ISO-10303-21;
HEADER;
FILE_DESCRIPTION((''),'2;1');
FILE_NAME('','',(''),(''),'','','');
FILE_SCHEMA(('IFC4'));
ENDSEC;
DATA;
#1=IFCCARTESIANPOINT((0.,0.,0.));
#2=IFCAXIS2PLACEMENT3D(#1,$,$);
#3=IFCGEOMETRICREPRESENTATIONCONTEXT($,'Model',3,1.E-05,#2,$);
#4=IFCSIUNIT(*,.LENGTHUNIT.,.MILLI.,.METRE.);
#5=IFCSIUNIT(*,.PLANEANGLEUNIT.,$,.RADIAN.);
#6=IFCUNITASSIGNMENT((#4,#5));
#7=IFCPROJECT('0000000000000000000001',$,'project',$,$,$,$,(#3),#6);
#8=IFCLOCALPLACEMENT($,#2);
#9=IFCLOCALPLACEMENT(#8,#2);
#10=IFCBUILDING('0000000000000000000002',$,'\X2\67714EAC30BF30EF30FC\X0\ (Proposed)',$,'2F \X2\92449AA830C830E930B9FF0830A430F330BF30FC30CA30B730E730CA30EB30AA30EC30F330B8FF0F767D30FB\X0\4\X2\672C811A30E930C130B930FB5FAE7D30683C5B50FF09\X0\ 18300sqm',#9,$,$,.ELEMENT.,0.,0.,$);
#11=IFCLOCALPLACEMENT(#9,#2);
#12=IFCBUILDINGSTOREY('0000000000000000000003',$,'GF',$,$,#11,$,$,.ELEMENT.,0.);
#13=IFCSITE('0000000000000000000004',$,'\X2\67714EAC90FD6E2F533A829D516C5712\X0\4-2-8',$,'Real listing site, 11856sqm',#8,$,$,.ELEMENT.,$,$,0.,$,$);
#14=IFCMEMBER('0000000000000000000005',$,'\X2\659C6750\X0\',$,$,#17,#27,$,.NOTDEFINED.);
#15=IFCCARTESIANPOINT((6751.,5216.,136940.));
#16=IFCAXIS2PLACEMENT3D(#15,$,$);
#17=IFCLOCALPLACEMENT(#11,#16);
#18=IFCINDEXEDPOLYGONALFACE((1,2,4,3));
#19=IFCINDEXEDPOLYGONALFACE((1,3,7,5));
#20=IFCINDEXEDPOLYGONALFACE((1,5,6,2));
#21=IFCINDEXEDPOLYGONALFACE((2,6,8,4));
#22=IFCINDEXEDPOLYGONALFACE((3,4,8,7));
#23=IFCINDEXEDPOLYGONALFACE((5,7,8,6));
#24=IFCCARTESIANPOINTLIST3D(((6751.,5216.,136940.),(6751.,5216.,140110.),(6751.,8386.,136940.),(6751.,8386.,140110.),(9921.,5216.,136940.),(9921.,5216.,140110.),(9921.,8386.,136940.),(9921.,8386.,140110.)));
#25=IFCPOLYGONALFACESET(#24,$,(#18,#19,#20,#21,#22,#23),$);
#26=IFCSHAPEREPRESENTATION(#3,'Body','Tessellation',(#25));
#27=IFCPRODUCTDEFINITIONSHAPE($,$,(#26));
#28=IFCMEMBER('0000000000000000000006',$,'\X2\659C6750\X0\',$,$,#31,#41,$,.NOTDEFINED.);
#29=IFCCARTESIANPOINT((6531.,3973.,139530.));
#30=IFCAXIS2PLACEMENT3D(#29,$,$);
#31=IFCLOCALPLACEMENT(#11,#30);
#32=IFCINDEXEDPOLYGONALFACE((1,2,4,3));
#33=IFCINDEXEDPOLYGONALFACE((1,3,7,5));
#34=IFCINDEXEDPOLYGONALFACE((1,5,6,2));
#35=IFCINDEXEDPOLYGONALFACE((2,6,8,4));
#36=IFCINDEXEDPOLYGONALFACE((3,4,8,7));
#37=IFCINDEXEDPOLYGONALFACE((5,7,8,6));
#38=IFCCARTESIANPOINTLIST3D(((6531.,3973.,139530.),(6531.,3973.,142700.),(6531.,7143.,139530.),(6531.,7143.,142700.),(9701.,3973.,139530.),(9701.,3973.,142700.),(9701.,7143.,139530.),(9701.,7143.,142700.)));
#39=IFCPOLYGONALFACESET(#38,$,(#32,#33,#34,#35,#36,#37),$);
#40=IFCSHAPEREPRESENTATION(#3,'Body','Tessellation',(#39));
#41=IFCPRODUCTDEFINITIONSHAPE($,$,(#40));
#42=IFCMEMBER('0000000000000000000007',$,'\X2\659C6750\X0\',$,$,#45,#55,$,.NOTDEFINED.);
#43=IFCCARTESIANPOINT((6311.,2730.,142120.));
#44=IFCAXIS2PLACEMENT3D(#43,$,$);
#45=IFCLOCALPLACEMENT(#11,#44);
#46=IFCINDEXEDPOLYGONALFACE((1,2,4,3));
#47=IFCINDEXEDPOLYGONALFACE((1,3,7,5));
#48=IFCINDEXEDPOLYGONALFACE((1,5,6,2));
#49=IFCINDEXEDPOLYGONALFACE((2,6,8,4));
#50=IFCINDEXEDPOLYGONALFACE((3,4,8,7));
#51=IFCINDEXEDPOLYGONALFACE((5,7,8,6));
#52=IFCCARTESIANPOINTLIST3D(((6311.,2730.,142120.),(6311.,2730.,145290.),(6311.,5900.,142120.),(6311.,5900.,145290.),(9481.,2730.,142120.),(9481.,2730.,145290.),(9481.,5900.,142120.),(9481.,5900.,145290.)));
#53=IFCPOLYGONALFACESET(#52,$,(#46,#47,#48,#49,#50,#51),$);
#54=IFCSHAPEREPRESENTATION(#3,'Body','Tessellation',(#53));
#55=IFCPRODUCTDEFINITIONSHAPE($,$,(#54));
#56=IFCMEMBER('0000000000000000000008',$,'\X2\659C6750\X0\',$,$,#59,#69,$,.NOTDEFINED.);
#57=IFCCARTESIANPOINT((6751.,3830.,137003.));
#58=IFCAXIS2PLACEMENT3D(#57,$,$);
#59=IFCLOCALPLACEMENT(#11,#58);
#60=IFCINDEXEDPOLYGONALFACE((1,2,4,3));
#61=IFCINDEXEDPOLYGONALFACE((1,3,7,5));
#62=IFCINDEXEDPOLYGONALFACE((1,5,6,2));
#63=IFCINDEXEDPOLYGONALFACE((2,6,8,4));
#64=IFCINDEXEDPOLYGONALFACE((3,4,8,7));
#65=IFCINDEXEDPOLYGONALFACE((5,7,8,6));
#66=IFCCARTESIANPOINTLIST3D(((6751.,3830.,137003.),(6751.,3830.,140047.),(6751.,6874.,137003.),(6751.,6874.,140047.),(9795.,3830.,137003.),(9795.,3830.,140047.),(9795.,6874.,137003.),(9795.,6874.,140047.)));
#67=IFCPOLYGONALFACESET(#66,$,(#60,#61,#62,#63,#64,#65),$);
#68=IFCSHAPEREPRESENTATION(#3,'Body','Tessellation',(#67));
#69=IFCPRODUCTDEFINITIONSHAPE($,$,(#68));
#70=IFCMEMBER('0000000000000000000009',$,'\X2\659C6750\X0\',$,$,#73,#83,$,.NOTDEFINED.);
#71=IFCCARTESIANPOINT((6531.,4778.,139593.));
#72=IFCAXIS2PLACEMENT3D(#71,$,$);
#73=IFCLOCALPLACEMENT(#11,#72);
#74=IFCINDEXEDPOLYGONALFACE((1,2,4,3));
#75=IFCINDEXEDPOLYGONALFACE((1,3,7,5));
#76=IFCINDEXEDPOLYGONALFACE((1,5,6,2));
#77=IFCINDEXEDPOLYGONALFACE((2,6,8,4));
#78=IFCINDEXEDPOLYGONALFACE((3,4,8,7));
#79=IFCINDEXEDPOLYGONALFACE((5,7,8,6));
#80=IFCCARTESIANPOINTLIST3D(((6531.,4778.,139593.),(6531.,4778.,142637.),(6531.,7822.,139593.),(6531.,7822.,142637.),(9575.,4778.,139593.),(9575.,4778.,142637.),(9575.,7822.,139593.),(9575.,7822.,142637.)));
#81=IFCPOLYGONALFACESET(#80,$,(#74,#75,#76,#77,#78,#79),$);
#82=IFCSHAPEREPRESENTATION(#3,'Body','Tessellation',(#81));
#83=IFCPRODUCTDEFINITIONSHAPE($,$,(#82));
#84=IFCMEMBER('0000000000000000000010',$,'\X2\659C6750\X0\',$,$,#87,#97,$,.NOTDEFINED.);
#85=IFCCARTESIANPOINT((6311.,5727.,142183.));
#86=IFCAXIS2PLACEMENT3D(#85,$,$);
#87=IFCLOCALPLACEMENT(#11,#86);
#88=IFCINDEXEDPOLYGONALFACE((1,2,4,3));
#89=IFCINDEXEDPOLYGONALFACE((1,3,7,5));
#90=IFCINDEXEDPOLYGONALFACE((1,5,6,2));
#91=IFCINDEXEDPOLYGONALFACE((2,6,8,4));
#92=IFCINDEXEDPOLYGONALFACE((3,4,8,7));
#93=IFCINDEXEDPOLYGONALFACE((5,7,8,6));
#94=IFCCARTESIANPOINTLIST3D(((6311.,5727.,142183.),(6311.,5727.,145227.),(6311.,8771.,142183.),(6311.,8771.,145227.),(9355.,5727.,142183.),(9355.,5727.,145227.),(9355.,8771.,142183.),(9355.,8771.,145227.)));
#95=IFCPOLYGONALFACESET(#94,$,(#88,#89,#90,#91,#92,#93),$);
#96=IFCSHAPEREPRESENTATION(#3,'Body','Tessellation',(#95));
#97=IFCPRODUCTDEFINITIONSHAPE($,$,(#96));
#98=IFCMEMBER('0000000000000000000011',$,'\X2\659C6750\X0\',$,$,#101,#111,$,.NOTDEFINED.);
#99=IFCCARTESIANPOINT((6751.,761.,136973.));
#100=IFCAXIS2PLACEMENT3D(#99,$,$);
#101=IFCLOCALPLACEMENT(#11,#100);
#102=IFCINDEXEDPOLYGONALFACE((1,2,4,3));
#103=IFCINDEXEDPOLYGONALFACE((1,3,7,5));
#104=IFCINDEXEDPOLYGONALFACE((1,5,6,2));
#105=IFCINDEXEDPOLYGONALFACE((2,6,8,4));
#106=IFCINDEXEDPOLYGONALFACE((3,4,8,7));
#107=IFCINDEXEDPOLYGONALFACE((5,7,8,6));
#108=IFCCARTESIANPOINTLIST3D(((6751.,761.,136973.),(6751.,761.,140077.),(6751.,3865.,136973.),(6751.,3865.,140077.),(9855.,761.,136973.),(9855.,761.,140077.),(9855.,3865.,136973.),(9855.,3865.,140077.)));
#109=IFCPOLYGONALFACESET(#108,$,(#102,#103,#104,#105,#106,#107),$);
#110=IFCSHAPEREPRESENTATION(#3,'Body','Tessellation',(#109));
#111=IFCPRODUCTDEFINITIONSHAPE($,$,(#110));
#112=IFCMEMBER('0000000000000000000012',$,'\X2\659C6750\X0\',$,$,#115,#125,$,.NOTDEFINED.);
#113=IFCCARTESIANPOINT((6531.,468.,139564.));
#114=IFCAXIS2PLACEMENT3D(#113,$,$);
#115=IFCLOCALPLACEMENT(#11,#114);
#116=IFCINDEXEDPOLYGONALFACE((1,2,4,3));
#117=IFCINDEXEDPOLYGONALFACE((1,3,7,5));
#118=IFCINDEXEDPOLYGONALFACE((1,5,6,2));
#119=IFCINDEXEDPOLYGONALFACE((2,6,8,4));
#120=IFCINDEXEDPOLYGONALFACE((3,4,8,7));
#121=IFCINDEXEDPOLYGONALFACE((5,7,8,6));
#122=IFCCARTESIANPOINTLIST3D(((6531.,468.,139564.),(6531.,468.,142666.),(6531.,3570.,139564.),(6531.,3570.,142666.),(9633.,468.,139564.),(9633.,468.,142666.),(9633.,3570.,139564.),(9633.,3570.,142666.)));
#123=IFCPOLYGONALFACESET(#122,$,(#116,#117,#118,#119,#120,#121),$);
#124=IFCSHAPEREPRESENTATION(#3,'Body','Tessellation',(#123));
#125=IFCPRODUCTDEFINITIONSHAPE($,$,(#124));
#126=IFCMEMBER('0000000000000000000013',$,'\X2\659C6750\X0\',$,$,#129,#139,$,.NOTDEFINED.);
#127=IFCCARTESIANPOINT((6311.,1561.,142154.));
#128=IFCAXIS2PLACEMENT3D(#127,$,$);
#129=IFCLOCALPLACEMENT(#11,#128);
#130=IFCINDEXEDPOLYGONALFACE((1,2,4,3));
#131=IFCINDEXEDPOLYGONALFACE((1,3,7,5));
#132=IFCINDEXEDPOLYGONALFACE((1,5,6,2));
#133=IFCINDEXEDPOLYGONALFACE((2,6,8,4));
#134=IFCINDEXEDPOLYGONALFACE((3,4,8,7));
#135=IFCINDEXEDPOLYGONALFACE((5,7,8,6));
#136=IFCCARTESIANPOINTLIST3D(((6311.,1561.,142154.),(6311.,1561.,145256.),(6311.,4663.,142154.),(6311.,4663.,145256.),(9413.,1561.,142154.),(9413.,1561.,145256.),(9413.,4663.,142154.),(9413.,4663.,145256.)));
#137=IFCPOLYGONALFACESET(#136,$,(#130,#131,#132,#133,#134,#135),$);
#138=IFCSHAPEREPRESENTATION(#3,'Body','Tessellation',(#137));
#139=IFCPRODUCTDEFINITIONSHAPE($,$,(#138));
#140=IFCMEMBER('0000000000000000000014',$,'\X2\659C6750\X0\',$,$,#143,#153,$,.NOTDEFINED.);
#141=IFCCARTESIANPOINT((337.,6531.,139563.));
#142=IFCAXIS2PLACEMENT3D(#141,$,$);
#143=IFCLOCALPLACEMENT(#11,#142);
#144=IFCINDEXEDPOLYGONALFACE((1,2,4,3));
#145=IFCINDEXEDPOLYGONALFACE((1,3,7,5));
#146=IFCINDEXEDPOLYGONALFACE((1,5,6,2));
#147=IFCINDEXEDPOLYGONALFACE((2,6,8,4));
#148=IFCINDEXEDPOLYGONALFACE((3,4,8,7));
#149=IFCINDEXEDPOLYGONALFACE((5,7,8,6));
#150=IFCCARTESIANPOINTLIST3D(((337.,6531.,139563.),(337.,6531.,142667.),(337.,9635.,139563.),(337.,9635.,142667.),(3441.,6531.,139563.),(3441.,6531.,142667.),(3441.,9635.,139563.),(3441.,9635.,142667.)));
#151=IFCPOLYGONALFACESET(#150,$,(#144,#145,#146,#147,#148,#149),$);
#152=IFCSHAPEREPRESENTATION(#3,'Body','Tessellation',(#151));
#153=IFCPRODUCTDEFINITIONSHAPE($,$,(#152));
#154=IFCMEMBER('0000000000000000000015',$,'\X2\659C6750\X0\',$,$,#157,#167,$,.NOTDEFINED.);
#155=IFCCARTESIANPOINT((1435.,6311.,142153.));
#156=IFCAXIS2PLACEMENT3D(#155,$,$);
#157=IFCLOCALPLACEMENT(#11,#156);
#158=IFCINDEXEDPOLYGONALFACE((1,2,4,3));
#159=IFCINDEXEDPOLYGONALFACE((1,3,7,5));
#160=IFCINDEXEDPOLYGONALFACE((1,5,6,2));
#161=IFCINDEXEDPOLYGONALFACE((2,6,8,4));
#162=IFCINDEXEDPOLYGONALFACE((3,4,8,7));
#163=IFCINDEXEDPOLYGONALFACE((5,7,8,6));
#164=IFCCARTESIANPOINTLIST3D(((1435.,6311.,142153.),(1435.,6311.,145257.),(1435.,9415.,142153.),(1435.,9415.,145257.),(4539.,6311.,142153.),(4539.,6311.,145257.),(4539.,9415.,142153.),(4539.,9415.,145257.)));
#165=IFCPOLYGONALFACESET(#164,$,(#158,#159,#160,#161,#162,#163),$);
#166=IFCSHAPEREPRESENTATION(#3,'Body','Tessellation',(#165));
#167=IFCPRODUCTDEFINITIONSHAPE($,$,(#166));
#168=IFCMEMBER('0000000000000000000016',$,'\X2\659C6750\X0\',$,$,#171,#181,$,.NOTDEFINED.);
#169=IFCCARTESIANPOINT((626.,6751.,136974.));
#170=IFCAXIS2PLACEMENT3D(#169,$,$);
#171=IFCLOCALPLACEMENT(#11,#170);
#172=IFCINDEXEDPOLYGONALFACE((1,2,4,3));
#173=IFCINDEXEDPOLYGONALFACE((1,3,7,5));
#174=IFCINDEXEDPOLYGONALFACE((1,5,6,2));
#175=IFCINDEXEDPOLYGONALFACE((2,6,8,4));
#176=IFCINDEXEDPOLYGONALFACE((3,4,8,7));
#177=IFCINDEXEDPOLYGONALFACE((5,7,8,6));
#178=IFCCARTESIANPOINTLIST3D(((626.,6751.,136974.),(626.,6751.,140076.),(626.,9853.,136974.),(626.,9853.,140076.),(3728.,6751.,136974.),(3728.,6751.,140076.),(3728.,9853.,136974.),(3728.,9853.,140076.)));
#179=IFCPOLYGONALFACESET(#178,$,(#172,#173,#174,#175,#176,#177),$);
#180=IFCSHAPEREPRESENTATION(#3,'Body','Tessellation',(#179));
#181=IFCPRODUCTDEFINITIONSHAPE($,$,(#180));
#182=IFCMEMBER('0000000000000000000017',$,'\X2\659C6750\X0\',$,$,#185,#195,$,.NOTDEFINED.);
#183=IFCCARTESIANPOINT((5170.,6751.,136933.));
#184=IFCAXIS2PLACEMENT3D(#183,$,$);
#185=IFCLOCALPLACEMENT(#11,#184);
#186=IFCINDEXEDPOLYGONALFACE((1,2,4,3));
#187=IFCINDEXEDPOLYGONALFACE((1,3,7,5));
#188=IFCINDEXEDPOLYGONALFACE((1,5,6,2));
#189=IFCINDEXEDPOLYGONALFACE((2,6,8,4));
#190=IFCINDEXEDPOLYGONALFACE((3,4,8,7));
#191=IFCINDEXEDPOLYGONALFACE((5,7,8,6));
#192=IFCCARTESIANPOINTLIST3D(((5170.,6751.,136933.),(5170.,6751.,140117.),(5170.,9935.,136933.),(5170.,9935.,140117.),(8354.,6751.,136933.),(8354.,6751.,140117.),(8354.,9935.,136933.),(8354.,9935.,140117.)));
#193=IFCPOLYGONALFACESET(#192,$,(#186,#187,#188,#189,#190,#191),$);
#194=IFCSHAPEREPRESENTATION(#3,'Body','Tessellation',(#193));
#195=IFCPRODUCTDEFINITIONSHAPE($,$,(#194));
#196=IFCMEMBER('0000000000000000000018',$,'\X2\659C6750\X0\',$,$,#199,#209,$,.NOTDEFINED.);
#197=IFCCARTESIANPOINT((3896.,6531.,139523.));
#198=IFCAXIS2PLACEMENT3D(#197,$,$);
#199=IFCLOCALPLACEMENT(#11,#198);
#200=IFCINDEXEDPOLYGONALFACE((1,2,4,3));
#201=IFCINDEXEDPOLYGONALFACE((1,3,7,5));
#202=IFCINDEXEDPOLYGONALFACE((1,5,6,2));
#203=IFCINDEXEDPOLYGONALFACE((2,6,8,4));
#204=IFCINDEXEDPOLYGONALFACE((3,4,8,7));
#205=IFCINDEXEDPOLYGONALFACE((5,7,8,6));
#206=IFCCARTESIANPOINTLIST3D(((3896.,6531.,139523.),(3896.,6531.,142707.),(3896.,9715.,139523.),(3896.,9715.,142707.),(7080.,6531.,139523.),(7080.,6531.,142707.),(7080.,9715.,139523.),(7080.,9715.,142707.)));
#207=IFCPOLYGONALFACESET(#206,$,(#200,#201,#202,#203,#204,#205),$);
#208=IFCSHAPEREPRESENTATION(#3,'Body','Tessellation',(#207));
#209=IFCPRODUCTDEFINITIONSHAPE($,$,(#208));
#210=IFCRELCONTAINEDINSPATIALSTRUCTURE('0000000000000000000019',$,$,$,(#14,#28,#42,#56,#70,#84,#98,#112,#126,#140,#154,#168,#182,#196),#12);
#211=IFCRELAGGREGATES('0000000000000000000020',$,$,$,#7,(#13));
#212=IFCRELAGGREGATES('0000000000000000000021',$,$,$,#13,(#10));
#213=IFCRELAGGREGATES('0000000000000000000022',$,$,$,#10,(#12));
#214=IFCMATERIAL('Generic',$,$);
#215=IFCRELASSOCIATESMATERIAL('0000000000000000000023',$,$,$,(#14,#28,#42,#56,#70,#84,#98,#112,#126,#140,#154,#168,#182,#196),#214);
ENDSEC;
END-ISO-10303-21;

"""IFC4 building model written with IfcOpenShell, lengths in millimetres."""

from ifc_helpers import new_model, si_unit, frame, frame_2d, origin, place, context, project, spatial, rectangle, extrude, material, element, save


model = new_model("IFC4")

# Units and contexts
model_context = context("Model", 3, precision=1e-05, world=origin())
ifc_project = project(units=[si_unit("LENGTHUNIT", "METRE", prefix="MILLI"), si_unit("PLANEANGLEUNIT", "RADIAN")], contexts=[model_context])

# Site, building, storey
site_placement = place(None, origin())
site = spatial("IfcSite", under=ifc_project, at=site_placement, Name="東京都港区芝公園4-2-8", ObjectType="Real listing site, 11856sqm", CompositionType="ELEMENT", RefElevation=0.0)
building_placement = place(site_placement, origin())
building = spatial("IfcBuilding", under=site, at=building_placement, Name="東京タワー (Proposed)", ObjectType="2F 鉄骨トラス（インターナショナルオレンジ／白・4本脚ラチス・微細格子） 18300sqm", CompositionType="ELEMENT", ElevationOfRefHeight=0.0, ElevationOfTerrain=0.0)
storey_placement = place(building_placement, origin())
storey = spatial("IfcBuildingStorey", under=building, at=storey_placement, Name="GF", CompositionType="ELEMENT", Elevation=0.0)

# Members
ifc_material = material(Name="Generic")
member_1_placement = place(storey_placement, frame((6751.0, 5216.0, 136940.0)))
element("IfcMember", 1, at=member_1_placement, inside=storey, material=ifc_material, Name="斜材", PredefinedType="NOTDEFINED", context=model_context, shape_type="SweptSolid", body=[
    extrude(rectangle(XDim=3170.0, YDim=3170.0, at=frame_2d((1585.0, 1585.0))), frame((6751.0, 5216.0, 136940.0)), (0.0, 0.0, 1.0), 3170.0),
])
member_2_placement = place(storey_placement, frame((6531.0, 3973.0, 139530.0)))
element("IfcMember", 2, at=member_2_placement, inside=storey, material=ifc_material, Name="斜材", PredefinedType="NOTDEFINED", context=model_context, shape_type="SweptSolid", body=[
    extrude(rectangle(XDim=3170.0, YDim=3170.0, at=frame_2d((1585.0, 1585.0))), frame((6531.0, 3973.0, 139530.0)), (0.0, 0.0, 1.0), 3170.0),
])
member_3_placement = place(storey_placement, frame((6311.0, 2730.0, 142120.0)))
element("IfcMember", 3, at=member_3_placement, inside=storey, material=ifc_material, Name="斜材", PredefinedType="NOTDEFINED", context=model_context, shape_type="SweptSolid", body=[
    extrude(rectangle(XDim=3170.0, YDim=3170.0, at=frame_2d((1585.0, 1585.0))), frame((6311.0, 2730.0, 142120.0)), (0.0, 0.0, 1.0), 3170.0),
])
member_4_placement = place(storey_placement, frame((6751.0, 3830.0, 137003.0)))
element("IfcMember", 4, at=member_4_placement, inside=storey, material=ifc_material, Name="斜材", PredefinedType="NOTDEFINED", context=model_context, shape_type="SweptSolid", body=[
    extrude(rectangle(XDim=3044.0, YDim=3044.0, at=frame_2d((1522.0, 1522.0))), frame((6751.0, 3830.0, 137003.0)), (0.0, 0.0, 1.0), 3044.0),
])
member_5_placement = place(storey_placement, frame((6531.0, 4778.0, 139593.0)))
element("IfcMember", 5, at=member_5_placement, inside=storey, material=ifc_material, Name="斜材", PredefinedType="NOTDEFINED", context=model_context, shape_type="SweptSolid", body=[
    extrude(rectangle(XDim=3044.0, YDim=3044.0, at=frame_2d((1522.0, 1522.0))), frame((6531.0, 4778.0, 139593.0)), (0.0, 0.0, 1.0), 3044.0),
])
member_6_placement = place(storey_placement, frame((6311.0, 5727.0, 142183.0)))
element("IfcMember", 6, at=member_6_placement, inside=storey, material=ifc_material, Name="斜材", PredefinedType="NOTDEFINED", context=model_context, shape_type="SweptSolid", body=[
    extrude(rectangle(XDim=3044.0, YDim=3044.0, at=frame_2d((1522.0, 1522.0))), frame((6311.0, 5727.0, 142183.0)), (0.0, 0.0, 1.0), 3044.0),
])
member_7_placement = place(storey_placement, frame((6751.0, 761.0, 136973.0)))
element("IfcMember", 7, at=member_7_placement, inside=storey, material=ifc_material, Name="斜材", PredefinedType="NOTDEFINED", context=model_context, shape_type="SweptSolid", body=[
    extrude(rectangle(XDim=3104.0, YDim=3104.0, at=frame_2d((1552.0, 1552.0))), frame((6751.0, 761.0, 136973.0)), (0.0, 0.0, 1.0), 3104.0),
])
member_8_placement = place(storey_placement, frame((6531.0, 468.0, 139564.0)))
element("IfcMember", 8, at=member_8_placement, inside=storey, material=ifc_material, Name="斜材", PredefinedType="NOTDEFINED", context=model_context, shape_type="SweptSolid", body=[
    extrude(rectangle(XDim=3102.0, YDim=3102.0, at=frame_2d((1551.0, 1551.0))), frame((6531.0, 468.0, 139564.0)), (0.0, 0.0, 1.0), 3102.0),
])
member_9_placement = place(storey_placement, frame((6311.0, 1561.0, 142154.0)))
element("IfcMember", 9, at=member_9_placement, inside=storey, material=ifc_material, Name="斜材", PredefinedType="NOTDEFINED", context=model_context, shape_type="SweptSolid", body=[
    extrude(rectangle(XDim=3102.0, YDim=3102.0, at=frame_2d((1551.0, 1551.0))), frame((6311.0, 1561.0, 142154.0)), (0.0, 0.0, 1.0), 3102.0),
])
member_10_placement = place(storey_placement, frame((337.0, 6531.0, 139563.0)))
element("IfcMember", 10, at=member_10_placement, inside=storey, material=ifc_material, Name="斜材", PredefinedType="NOTDEFINED", context=model_context, shape_type="SweptSolid", body=[
    extrude(rectangle(XDim=3104.0, YDim=3104.0, at=frame_2d((1552.0, 1552.0))), frame((337.0, 6531.0, 139563.0)), (0.0, 0.0, 1.0), 3104.0),
])
member_11_placement = place(storey_placement, frame((1435.0, 6311.0, 142153.0)))
element("IfcMember", 11, at=member_11_placement, inside=storey, material=ifc_material, Name="斜材", PredefinedType="NOTDEFINED", context=model_context, shape_type="SweptSolid", body=[
    extrude(rectangle(XDim=3104.0, YDim=3104.0, at=frame_2d((1552.0, 1552.0))), frame((1435.0, 6311.0, 142153.0)), (0.0, 0.0, 1.0), 3104.0),
])
member_12_placement = place(storey_placement, frame((626.0, 6751.0, 136974.0)))
element("IfcMember", 12, at=member_12_placement, inside=storey, material=ifc_material, Name="斜材", PredefinedType="NOTDEFINED", context=model_context, shape_type="SweptSolid", body=[
    extrude(rectangle(XDim=3102.0, YDim=3102.0, at=frame_2d((1551.0, 1551.0))), frame((626.0, 6751.0, 136974.0)), (0.0, 0.0, 1.0), 3102.0),
])
member_13_placement = place(storey_placement, frame((5170.0, 6751.0, 136933.0)))
element("IfcMember", 13, at=member_13_placement, inside=storey, material=ifc_material, Name="斜材", PredefinedType="NOTDEFINED", context=model_context, shape_type="SweptSolid", body=[
    extrude(rectangle(XDim=3184.0, YDim=3184.0, at=frame_2d((1592.0, 1592.0))), frame((5170.0, 6751.0, 136933.0)), (0.0, 0.0, 1.0), 3184.0),
])
member_14_placement = place(storey_placement, frame((3896.0, 6531.0, 139523.0)))
element("IfcMember", 14, at=member_14_placement, inside=storey, material=ifc_material, Name="斜材", PredefinedType="NOTDEFINED", context=model_context, shape_type="SweptSolid", body=[
    extrude(rectangle(XDim=3184.0, YDim=3184.0, at=frame_2d((1592.0, 1592.0))), frame((3896.0, 6531.0, 139523.0)), (0.0, 0.0, 1.0), 3184.0),
])

save(model, "model.ifc")
